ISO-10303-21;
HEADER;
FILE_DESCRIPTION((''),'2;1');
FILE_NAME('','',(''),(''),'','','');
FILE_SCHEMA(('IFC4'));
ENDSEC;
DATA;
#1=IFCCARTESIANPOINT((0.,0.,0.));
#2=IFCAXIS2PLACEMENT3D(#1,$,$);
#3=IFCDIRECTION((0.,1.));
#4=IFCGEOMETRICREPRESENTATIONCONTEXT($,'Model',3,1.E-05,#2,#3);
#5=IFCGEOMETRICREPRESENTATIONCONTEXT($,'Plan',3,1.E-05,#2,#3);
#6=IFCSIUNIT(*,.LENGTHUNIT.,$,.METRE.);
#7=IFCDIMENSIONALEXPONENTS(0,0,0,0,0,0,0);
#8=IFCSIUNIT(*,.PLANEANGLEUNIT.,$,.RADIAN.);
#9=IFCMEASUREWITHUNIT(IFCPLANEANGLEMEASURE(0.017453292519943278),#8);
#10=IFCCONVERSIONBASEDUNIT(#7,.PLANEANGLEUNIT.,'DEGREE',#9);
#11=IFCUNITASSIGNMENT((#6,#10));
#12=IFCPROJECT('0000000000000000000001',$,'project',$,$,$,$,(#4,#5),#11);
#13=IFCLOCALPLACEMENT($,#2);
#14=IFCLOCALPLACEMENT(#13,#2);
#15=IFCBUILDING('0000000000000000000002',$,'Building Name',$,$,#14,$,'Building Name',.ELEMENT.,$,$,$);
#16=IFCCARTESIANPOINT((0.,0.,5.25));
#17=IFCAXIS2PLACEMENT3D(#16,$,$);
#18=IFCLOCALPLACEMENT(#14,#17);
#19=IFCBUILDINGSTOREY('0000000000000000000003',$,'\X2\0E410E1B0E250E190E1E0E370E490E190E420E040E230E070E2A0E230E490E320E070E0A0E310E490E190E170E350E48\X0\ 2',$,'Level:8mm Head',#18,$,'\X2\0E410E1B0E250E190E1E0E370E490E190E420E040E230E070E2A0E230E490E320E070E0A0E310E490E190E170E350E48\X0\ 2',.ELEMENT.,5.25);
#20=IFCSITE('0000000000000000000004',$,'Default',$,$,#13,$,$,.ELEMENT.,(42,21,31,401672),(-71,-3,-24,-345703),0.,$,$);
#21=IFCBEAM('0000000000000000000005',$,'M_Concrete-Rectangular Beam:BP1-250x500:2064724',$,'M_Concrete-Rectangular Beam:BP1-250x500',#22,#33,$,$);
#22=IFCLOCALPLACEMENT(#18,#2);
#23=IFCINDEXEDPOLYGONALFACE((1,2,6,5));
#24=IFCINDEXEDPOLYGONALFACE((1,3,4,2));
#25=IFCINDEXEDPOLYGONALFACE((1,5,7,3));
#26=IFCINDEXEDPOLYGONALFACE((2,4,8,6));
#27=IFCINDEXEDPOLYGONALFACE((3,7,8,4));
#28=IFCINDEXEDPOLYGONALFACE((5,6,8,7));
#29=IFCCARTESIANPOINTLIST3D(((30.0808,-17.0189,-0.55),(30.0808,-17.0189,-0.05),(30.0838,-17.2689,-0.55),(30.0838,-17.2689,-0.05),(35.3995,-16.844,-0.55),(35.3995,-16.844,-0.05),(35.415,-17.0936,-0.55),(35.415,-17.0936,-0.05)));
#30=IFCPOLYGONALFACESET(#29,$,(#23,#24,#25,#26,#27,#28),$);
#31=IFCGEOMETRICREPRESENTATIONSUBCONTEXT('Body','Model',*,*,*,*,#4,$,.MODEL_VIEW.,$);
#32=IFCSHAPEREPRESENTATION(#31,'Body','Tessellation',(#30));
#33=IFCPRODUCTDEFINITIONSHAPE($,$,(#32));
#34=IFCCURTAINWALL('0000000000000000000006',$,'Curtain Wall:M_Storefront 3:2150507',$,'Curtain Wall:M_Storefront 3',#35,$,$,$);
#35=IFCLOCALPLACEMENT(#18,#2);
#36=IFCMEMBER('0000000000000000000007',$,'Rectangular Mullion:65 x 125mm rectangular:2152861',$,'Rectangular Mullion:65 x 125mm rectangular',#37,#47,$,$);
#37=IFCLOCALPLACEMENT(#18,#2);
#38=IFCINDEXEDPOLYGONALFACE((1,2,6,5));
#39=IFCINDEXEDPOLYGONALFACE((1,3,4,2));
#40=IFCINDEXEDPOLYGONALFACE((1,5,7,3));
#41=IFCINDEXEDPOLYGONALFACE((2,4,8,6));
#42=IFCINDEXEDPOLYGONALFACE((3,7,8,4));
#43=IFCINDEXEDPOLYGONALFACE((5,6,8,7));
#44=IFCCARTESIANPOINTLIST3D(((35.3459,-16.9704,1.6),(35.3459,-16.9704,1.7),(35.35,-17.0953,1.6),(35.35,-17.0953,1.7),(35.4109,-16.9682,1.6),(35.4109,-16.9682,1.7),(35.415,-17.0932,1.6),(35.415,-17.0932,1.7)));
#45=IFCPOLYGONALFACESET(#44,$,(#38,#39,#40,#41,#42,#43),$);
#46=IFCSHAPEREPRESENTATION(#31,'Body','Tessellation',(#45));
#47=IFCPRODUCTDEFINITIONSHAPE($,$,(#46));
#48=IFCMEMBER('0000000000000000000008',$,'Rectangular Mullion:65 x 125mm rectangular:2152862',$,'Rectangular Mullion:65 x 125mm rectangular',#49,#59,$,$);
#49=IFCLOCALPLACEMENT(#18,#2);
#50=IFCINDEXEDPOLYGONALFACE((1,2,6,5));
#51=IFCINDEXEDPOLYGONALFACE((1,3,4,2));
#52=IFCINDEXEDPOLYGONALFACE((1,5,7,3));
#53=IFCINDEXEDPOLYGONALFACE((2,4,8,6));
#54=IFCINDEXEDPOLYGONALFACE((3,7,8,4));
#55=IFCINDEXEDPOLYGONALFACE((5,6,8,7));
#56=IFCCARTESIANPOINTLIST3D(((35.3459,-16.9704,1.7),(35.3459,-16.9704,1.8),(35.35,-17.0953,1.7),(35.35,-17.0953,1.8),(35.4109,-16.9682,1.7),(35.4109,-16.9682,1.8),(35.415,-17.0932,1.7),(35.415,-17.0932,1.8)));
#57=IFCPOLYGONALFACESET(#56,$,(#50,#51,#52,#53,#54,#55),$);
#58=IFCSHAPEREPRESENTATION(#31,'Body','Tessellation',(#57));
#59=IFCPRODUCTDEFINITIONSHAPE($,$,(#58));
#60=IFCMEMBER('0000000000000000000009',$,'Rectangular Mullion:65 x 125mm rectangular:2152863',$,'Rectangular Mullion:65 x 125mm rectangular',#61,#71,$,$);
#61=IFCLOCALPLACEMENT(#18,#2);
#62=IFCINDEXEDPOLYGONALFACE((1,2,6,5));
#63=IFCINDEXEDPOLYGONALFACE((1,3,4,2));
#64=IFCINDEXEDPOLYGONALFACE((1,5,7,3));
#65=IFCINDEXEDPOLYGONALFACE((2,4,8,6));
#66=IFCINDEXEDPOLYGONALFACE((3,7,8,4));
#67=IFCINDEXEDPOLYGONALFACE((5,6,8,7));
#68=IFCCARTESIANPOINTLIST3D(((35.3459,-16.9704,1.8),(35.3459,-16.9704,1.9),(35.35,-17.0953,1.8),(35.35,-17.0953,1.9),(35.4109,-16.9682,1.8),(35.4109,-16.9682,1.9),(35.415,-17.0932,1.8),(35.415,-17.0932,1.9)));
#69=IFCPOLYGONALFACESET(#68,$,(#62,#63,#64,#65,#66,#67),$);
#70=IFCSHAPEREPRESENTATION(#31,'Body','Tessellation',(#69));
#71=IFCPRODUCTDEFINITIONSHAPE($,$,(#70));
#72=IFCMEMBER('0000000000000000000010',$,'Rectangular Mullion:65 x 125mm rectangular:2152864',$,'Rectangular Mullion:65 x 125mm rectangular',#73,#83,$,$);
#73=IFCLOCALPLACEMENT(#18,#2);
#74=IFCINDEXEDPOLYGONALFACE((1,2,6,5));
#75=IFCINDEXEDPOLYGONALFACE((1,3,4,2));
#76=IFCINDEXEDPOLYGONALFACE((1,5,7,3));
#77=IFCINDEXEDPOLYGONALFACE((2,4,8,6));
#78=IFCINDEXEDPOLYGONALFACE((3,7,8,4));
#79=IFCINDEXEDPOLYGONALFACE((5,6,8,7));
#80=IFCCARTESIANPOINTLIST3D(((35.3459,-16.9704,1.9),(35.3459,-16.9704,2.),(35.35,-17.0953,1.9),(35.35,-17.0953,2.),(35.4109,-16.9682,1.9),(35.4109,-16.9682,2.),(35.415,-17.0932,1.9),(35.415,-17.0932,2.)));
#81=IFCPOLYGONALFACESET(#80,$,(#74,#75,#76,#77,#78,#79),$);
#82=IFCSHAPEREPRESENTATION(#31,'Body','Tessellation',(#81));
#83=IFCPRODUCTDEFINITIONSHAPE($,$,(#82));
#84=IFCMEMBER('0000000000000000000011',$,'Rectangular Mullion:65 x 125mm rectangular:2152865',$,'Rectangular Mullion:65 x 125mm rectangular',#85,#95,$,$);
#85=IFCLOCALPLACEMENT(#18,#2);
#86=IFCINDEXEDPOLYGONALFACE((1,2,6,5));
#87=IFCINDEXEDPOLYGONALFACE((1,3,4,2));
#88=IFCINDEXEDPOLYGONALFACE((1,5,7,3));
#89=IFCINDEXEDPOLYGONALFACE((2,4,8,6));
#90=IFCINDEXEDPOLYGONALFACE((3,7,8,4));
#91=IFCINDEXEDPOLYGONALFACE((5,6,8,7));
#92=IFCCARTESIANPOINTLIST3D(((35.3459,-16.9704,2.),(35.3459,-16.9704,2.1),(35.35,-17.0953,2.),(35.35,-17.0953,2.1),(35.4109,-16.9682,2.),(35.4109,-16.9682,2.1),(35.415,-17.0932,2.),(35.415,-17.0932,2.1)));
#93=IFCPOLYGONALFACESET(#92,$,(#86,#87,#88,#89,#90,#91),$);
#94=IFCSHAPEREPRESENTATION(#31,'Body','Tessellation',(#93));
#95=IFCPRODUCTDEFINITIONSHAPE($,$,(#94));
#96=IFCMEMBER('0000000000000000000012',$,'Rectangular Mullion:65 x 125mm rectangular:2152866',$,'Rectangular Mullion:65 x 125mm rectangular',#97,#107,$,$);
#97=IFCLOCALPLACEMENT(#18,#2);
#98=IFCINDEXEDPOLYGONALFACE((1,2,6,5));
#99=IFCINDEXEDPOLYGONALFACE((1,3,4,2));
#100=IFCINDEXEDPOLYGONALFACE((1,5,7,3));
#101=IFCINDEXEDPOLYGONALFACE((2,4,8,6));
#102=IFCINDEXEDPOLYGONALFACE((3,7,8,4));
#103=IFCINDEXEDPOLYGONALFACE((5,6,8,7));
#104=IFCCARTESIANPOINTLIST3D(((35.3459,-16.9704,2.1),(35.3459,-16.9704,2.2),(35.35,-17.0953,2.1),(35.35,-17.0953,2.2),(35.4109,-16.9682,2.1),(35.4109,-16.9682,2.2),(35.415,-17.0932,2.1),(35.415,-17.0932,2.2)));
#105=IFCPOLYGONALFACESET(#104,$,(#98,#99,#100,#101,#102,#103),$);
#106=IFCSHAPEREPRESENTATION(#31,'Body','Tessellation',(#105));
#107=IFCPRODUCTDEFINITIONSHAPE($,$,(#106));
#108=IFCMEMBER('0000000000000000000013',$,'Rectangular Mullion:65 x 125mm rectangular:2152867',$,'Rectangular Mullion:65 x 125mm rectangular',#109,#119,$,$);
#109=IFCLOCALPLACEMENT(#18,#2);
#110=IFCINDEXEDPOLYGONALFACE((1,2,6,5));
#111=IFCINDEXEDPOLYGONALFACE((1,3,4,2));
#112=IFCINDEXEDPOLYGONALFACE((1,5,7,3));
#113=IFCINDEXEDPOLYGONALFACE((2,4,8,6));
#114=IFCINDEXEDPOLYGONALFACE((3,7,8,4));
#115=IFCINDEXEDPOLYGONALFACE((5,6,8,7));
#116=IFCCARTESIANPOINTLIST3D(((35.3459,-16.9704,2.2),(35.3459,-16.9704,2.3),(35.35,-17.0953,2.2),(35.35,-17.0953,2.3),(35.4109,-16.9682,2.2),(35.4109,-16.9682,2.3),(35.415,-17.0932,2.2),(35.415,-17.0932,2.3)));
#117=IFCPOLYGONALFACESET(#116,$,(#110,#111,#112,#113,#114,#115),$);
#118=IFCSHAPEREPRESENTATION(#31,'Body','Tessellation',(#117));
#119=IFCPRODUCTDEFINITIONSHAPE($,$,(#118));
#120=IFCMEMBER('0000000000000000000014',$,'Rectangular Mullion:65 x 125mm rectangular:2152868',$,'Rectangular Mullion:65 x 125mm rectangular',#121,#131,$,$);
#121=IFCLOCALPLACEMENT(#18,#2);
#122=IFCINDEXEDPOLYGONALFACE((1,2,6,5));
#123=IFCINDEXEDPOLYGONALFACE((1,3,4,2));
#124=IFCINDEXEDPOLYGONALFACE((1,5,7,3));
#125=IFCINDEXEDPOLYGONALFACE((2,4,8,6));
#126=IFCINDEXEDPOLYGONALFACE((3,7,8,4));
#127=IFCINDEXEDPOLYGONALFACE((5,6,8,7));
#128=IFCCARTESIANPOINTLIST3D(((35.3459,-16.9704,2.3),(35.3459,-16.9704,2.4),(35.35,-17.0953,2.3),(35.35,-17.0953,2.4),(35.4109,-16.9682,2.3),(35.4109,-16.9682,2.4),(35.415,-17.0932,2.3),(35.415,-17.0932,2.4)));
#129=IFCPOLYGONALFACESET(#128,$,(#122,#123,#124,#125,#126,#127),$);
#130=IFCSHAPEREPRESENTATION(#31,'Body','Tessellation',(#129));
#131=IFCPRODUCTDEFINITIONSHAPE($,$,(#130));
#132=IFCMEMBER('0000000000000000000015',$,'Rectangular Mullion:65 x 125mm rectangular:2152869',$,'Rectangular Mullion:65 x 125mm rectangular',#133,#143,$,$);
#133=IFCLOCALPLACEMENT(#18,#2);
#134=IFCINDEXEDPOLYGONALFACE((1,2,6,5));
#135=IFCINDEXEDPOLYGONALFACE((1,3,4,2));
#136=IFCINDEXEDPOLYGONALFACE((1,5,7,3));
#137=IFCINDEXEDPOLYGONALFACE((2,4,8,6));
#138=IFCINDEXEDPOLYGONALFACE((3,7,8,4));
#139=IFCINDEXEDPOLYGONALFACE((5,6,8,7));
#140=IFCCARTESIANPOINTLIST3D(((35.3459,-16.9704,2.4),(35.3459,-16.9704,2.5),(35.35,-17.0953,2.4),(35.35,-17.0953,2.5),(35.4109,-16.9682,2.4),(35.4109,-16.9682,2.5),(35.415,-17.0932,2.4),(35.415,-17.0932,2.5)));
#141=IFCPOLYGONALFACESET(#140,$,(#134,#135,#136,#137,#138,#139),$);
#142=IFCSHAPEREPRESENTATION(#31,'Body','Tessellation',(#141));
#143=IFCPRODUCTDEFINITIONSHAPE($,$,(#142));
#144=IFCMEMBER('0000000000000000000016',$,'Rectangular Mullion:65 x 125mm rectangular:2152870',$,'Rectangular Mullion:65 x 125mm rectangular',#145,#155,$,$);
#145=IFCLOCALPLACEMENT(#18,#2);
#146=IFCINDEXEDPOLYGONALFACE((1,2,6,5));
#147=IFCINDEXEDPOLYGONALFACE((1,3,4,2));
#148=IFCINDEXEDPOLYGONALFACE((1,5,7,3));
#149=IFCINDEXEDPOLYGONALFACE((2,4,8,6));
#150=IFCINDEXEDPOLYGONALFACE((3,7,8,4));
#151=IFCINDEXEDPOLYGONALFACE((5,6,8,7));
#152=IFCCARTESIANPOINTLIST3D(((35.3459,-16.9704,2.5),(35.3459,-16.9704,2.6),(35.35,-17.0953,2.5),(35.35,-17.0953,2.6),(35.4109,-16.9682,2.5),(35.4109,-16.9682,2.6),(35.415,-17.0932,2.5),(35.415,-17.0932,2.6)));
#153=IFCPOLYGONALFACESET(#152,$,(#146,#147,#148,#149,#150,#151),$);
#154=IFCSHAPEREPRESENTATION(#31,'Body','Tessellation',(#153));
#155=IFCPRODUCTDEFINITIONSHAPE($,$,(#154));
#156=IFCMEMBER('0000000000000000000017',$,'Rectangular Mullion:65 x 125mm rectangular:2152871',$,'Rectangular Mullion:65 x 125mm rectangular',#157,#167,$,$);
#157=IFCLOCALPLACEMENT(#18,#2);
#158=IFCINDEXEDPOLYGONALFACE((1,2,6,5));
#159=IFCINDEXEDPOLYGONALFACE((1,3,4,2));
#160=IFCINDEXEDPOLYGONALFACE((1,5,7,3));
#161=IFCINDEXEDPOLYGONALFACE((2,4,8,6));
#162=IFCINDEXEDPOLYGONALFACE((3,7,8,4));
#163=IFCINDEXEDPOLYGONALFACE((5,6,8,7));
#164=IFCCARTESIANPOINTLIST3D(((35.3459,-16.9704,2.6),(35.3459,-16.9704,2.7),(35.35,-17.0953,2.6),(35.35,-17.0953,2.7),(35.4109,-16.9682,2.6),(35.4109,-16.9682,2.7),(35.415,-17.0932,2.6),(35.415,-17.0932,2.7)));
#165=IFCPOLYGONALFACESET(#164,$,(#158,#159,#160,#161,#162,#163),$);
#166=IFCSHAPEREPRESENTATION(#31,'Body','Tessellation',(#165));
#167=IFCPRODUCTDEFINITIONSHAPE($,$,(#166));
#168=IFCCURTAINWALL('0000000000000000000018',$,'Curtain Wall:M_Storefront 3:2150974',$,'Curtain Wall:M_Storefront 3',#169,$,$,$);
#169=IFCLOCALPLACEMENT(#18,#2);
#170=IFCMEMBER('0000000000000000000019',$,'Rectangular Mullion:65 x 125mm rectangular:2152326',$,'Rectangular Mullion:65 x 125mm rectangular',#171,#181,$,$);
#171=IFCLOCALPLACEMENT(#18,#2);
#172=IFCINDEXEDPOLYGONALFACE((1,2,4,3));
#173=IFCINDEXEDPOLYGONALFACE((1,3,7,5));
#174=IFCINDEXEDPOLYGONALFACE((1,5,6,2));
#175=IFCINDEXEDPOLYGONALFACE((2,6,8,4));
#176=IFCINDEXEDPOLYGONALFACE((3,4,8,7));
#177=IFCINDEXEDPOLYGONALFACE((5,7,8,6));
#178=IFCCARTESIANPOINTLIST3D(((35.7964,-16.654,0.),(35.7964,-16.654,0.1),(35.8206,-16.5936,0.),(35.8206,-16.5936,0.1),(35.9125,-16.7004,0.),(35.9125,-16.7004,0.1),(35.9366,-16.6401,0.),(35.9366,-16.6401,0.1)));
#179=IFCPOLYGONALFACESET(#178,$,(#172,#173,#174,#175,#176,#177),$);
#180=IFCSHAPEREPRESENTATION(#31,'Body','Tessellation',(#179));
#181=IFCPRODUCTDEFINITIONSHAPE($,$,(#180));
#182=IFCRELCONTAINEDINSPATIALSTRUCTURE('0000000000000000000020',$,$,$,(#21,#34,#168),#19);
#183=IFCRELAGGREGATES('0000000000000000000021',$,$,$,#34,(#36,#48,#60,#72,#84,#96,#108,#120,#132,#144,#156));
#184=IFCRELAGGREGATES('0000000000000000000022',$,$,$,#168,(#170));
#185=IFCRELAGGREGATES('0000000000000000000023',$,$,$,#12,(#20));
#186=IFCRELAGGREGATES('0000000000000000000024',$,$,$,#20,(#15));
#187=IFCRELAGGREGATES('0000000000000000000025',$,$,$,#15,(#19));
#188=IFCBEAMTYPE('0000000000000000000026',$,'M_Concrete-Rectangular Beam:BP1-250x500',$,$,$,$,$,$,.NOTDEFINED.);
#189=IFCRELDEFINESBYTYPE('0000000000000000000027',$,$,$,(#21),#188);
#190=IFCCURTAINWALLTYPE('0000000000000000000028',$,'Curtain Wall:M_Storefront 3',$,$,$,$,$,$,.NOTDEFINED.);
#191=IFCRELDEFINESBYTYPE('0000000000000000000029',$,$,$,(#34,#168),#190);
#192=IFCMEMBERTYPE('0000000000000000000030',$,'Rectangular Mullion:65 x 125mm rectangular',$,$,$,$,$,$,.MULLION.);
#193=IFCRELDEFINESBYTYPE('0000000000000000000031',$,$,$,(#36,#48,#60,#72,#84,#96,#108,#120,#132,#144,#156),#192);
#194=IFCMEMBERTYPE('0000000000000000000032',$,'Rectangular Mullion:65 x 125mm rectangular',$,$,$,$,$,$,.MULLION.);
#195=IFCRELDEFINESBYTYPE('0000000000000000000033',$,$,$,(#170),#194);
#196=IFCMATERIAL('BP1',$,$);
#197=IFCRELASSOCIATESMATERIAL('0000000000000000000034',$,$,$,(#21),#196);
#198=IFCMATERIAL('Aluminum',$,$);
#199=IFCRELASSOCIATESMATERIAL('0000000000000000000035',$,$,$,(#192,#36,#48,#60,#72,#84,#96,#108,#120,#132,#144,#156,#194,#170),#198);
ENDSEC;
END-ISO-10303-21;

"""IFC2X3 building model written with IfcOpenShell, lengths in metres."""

from ifc_helpers import new_model, entity, si_unit, converted_unit, direction, frame, frame_2d, origin, origin_2d_with_axis, place, context, subcontext, project, spatial, rectangle, extrude, clip, halfspace, source, transform, mapped, material, type_object, type_shapes, element, aggregate, save


model = new_model("IFC2X3")

# Units and contexts
model_context = context("Model", 3, precision=1e-05, world=origin(), true_north=direction((0.0, 1.0)))
plan_context = context("Plan", 3, precision=1e-05, world=origin(), true_north=direction((0.0, 1.0)))
body_context = subcontext(model_context, "Body", "Model", "MODEL_VIEW")
ifc_project = project(units=[si_unit("LENGTHUNIT", "METRE"), converted_unit("PLANEANGLEUNIT", "DEGREE", entity("IfcPlaneAngleMeasure", 0.017453292519943278), si_unit("PLANEANGLEUNIT", "RADIAN"), dimensions=[0, 0, 0, 0, 0, 0, 0])], contexts=[model_context, plan_context])

# Site, building, storey
site_placement = place(None, origin())
site = spatial("IfcSite", under=ifc_project, at=site_placement, Name="Default", CompositionType="ELEMENT", RefLatitude=(42, 21, 31, 401672), RefLongitude=(-71, -3, -24, -345703), RefElevation=0.0)
building_placement = place(site_placement, origin())
building = spatial("IfcBuilding", under=site, at=building_placement, Name="Building Name", LongName="Building Name", CompositionType="ELEMENT")
storey_placement = place(building_placement, frame((0.0, 0.0, 5.25)))
storey = spatial("IfcBuildingStorey", under=building, at=storey_placement, Name="แปลนพื้นโครงสร้างชั้นที่ 2", ObjectType="Level:8mm Head", LongName="แปลนพื้นโครงสร้างชั้นที่ 2", CompositionType="ELEMENT", Elevation=5.25)

# Beam
ifc_material_1 = material(Name="BP1")
beam_type = type_object("IfcBeamType", Name="M_Concrete-Rectangular Beam:BP1-250x500", PredefinedType="NOTDEFINED")
beam_placement = place(storey_placement, frame((35.415, -17.0936, -0.05), z_axis=(0.0, 0.0, 1.0), x_axis=(-0.99946, -0.032862, 0.0)))
element("IfcBeam", 1, at=beam_placement, inside=storey, type_object=beam_type, material=ifc_material_1, Name="M_Concrete-Rectangular Beam:BP1-250x500:2064724", ObjectType="M_Concrete-Rectangular Beam:BP1-250x500", context=body_context, shape_type="Clipping", body=[
    clip(clip(extrude(rectangle(XDim=0.5, YDim=0.25, at=frame_2d((0.0, 0.0), x_axis=(1.0, 0.0))), frame((0.0, -0.125, -0.25), z_axis=(1.0, 0.0, 0.0), x_axis=(0.0, 0.0, -1.0)), (0.0, 0.0, 1.0), 5.3341), halfspace(frame((5.3341, 0.0, 0.05), z_axis=(0.999782, -0.020897, 0.0), x_axis=(0.0, 0.0, -1.0)), False)), halfspace(frame((0.0146, -0.4998, 0.05), z_axis=(-0.999574, -0.029182, 0.0), x_axis=(0.0, 0.0, -1.0)), False)),
])

# Curtain walls, members
curtain_wall_type = type_object("IfcCurtainWallType", Name="Curtain Wall:M_Storefront 3", PredefinedType="NOTDEFINED")
curtain_wall_1_placement = place(storey_placement, frame((0.0, 0.0, -5.25)))
curtain_wall_1 = element("IfcCurtainWall", 2, at=curtain_wall_1_placement, inside=storey, type_object=curtain_wall_type, Name="Curtain Wall:M_Storefront 3:2150507", ObjectType="Curtain Wall:M_Storefront 3")
ifc_material_2 = material(Name="Aluminum")
member_type_1 = type_object("IfcMemberType", Name="Rectangular Mullion:65 x 125mm rectangular", PredefinedType="MULLION", material=ifc_material_2)
shared_shape_1 = source(origin(), body_context, "Body", "SweptSolid", [
    extrude(rectangle(XDim=0.065, YDim=0.125, at=origin_2d_with_axis()), frame((-0.0325, 0.0, -0.1), z_axis=(0.0, 0.0, 1.0), x_axis=(-1.0, 0.0, 0.0)), (0.0, 0.0, 1.0), 0.1),
])
type_shapes(member_type_1, [shared_shape_1])
member_1_placement = place(curtain_wall_1_placement, frame((35.4129, -17.0307, 6.85), z_axis=(0.0, 0.0, -1.0), x_axis=(0.99946, 0.032862, 0.0)))
member_1 = element("IfcMember", 3, at=member_1_placement, type_object=member_type_1, material=ifc_material_2, Name="Rectangular Mullion:65 x 125mm rectangular:2152861", ObjectType="Rectangular Mullion:65 x 125mm rectangular", context=body_context, shape_type="MappedRepresentation", body=[
    mapped(shared_shape_1, transform((0.0, 0.0, 0.0), scale=1.0)),
])
member_2_placement = place(curtain_wall_1_placement, frame((35.4129, -17.0307, 6.95), z_axis=(0.0, 0.0, -1.0), x_axis=(0.99946, 0.032862, 0.0)))
member_2 = element("IfcMember", 4, at=member_2_placement, type_object=member_type_1, material=ifc_material_2, Name="Rectangular Mullion:65 x 125mm rectangular:2152862", ObjectType="Rectangular Mullion:65 x 125mm rectangular", context=body_context, shape_type="MappedRepresentation", body=[
    mapped(shared_shape_1, transform((0.0, 0.0, 0.0), scale=1.0)),
])
member_3_placement = place(curtain_wall_1_placement, frame((35.4129, -17.0307, 7.05), z_axis=(0.0, 0.0, -1.0), x_axis=(0.99946, 0.032862, 0.0)))
member_3 = element("IfcMember", 5, at=member_3_placement, type_object=member_type_1, material=ifc_material_2, Name="Rectangular Mullion:65 x 125mm rectangular:2152863", ObjectType="Rectangular Mullion:65 x 125mm rectangular", context=body_context, shape_type="MappedRepresentation", body=[
    mapped(shared_shape_1, transform((0.0, 0.0, 0.0), scale=1.0)),
])
member_4_placement = place(curtain_wall_1_placement, frame((35.4129, -17.0307, 7.15), z_axis=(0.0, 0.0, -1.0), x_axis=(0.99946, 0.032862, 0.0)))
member_4 = element("IfcMember", 6, at=member_4_placement, type_object=member_type_1, material=ifc_material_2, Name="Rectangular Mullion:65 x 125mm rectangular:2152864", ObjectType="Rectangular Mullion:65 x 125mm rectangular", context=body_context, shape_type="MappedRepresentation", body=[
    mapped(shared_shape_1, transform((0.0, 0.0, 0.0), scale=1.0)),
])
member_5_placement = place(curtain_wall_1_placement, frame((35.4129, -17.0307, 7.25), z_axis=(0.0, 0.0, -1.0), x_axis=(0.99946, 0.032862, 0.0)))
member_5 = element("IfcMember", 7, at=member_5_placement, type_object=member_type_1, material=ifc_material_2, Name="Rectangular Mullion:65 x 125mm rectangular:2152865", ObjectType="Rectangular Mullion:65 x 125mm rectangular", context=body_context, shape_type="MappedRepresentation", body=[
    mapped(shared_shape_1, transform((0.0, 0.0, 0.0), scale=1.0)),
])
member_6_placement = place(curtain_wall_1_placement, frame((35.4129, -17.0307, 7.35), z_axis=(0.0, 0.0, -1.0), x_axis=(0.99946, 0.032862, 0.0)))
member_6 = element("IfcMember", 8, at=member_6_placement, type_object=member_type_1, material=ifc_material_2, Name="Rectangular Mullion:65 x 125mm rectangular:2152866", ObjectType="Rectangular Mullion:65 x 125mm rectangular", context=body_context, shape_type="MappedRepresentation", body=[
    mapped(shared_shape_1, transform((0.0, 0.0, 0.0), scale=1.0)),
])
member_7_placement = place(curtain_wall_1_placement, frame((35.4129, -17.0307, 7.45), z_axis=(0.0, 0.0, -1.0), x_axis=(0.99946, 0.032862, 0.0)))
member_7 = element("IfcMember", 9, at=member_7_placement, type_object=member_type_1, material=ifc_material_2, Name="Rectangular Mullion:65 x 125mm rectangular:2152867", ObjectType="Rectangular Mullion:65 x 125mm rectangular", context=body_context, shape_type="MappedRepresentation", body=[
    mapped(shared_shape_1, transform((0.0, 0.0, 0.0), scale=1.0)),
])
member_8_placement = place(curtain_wall_1_placement, frame((35.4129, -17.0307, 7.55), z_axis=(0.0, 0.0, -1.0), x_axis=(0.99946, 0.032862, 0.0)))
member_8 = element("IfcMember", 10, at=member_8_placement, type_object=member_type_1, material=ifc_material_2, Name="Rectangular Mullion:65 x 125mm rectangular:2152868", ObjectType="Rectangular Mullion:65 x 125mm rectangular", context=body_context, shape_type="MappedRepresentation", body=[
    mapped(shared_shape_1, transform((0.0, 0.0, 0.0), scale=1.0)),
])
member_9_placement = place(curtain_wall_1_placement, frame((35.4129, -17.0307, 7.65), z_axis=(0.0, 0.0, -1.0), x_axis=(0.99946, 0.032862, 0.0)))
member_9 = element("IfcMember", 11, at=member_9_placement, type_object=member_type_1, material=ifc_material_2, Name="Rectangular Mullion:65 x 125mm rectangular:2152869", ObjectType="Rectangular Mullion:65 x 125mm rectangular", context=body_context, shape_type="MappedRepresentation", body=[
    mapped(shared_shape_1, transform((0.0, 0.0, 0.0), scale=1.0)),
])
member_10_placement = place(curtain_wall_1_placement, frame((35.4129, -17.0307, 7.75), z_axis=(0.0, 0.0, -1.0), x_axis=(0.99946, 0.032862, 0.0)))
member_10 = element("IfcMember", 12, at=member_10_placement, type_object=member_type_1, material=ifc_material_2, Name="Rectangular Mullion:65 x 125mm rectangular:2152870", ObjectType="Rectangular Mullion:65 x 125mm rectangular", context=body_context, shape_type="MappedRepresentation", body=[
    mapped(shared_shape_1, transform((0.0, 0.0, 0.0), scale=1.0)),
])
member_11_placement = place(curtain_wall_1_placement, frame((35.4129, -17.0307, 7.85), z_axis=(0.0, 0.0, -1.0), x_axis=(0.99946, 0.032862, 0.0)))
member_11 = element("IfcMember", 13, at=member_11_placement, type_object=member_type_1, material=ifc_material_2, Name="Rectangular Mullion:65 x 125mm rectangular:2152871", ObjectType="Rectangular Mullion:65 x 125mm rectangular", context=body_context, shape_type="MappedRepresentation", body=[
    mapped(shared_shape_1, transform((0.0, 0.0, 0.0), scale=1.0)),
])
aggregate(curtain_wall_1, [member_1, member_2, member_3, member_4, member_5, member_6, member_7, member_8, member_9, member_10, member_11])
curtain_wall_2_placement = place(storey_placement, frame((0.0, 0.0, -5.25)))
curtain_wall_2 = element("IfcCurtainWall", 14, at=curtain_wall_2_placement, inside=storey, type_object=curtain_wall_type, Name="Curtain Wall:M_Storefront 3:2150974", ObjectType="Curtain Wall:M_Storefront 3")
member_type_2 = type_object("IfcMemberType", Name="Rectangular Mullion:65 x 125mm rectangular", PredefinedType="MULLION", material=ifc_material_2)
shared_shape_2 = source(origin(), body_context, "Body", "SweptSolid", [
    extrude(rectangle(XDim=0.065, YDim=0.125, at=origin_2d_with_axis()), frame((-0.0325, 0.0, -0.1), z_axis=(0.0, 0.0, 1.0), x_axis=(-1.0, 0.0, 0.0)), (0.0, 0.0, 1.0), 0.1),
])
type_shapes(member_type_2, [shared_shape_2])
member_12_placement = place(curtain_wall_2_placement, frame((35.8545, -16.6772, 5.35), z_axis=(0.0, 0.0, 1.0), x_axis=(-0.371573, -0.928404, 0.0)))
member_12 = element("IfcMember", 15, at=member_12_placement, type_object=member_type_2, material=ifc_material_2, Name="Rectangular Mullion:65 x 125mm rectangular:2152326", ObjectType="Rectangular Mullion:65 x 125mm rectangular", context=body_context, shape_type="MappedRepresentation", body=[
    mapped(shared_shape_2, transform((0.0, 0.0, 0.0), scale=1.0)),
])
aggregate(curtain_wall_2, [member_12])

save(model, "model.ifc")
